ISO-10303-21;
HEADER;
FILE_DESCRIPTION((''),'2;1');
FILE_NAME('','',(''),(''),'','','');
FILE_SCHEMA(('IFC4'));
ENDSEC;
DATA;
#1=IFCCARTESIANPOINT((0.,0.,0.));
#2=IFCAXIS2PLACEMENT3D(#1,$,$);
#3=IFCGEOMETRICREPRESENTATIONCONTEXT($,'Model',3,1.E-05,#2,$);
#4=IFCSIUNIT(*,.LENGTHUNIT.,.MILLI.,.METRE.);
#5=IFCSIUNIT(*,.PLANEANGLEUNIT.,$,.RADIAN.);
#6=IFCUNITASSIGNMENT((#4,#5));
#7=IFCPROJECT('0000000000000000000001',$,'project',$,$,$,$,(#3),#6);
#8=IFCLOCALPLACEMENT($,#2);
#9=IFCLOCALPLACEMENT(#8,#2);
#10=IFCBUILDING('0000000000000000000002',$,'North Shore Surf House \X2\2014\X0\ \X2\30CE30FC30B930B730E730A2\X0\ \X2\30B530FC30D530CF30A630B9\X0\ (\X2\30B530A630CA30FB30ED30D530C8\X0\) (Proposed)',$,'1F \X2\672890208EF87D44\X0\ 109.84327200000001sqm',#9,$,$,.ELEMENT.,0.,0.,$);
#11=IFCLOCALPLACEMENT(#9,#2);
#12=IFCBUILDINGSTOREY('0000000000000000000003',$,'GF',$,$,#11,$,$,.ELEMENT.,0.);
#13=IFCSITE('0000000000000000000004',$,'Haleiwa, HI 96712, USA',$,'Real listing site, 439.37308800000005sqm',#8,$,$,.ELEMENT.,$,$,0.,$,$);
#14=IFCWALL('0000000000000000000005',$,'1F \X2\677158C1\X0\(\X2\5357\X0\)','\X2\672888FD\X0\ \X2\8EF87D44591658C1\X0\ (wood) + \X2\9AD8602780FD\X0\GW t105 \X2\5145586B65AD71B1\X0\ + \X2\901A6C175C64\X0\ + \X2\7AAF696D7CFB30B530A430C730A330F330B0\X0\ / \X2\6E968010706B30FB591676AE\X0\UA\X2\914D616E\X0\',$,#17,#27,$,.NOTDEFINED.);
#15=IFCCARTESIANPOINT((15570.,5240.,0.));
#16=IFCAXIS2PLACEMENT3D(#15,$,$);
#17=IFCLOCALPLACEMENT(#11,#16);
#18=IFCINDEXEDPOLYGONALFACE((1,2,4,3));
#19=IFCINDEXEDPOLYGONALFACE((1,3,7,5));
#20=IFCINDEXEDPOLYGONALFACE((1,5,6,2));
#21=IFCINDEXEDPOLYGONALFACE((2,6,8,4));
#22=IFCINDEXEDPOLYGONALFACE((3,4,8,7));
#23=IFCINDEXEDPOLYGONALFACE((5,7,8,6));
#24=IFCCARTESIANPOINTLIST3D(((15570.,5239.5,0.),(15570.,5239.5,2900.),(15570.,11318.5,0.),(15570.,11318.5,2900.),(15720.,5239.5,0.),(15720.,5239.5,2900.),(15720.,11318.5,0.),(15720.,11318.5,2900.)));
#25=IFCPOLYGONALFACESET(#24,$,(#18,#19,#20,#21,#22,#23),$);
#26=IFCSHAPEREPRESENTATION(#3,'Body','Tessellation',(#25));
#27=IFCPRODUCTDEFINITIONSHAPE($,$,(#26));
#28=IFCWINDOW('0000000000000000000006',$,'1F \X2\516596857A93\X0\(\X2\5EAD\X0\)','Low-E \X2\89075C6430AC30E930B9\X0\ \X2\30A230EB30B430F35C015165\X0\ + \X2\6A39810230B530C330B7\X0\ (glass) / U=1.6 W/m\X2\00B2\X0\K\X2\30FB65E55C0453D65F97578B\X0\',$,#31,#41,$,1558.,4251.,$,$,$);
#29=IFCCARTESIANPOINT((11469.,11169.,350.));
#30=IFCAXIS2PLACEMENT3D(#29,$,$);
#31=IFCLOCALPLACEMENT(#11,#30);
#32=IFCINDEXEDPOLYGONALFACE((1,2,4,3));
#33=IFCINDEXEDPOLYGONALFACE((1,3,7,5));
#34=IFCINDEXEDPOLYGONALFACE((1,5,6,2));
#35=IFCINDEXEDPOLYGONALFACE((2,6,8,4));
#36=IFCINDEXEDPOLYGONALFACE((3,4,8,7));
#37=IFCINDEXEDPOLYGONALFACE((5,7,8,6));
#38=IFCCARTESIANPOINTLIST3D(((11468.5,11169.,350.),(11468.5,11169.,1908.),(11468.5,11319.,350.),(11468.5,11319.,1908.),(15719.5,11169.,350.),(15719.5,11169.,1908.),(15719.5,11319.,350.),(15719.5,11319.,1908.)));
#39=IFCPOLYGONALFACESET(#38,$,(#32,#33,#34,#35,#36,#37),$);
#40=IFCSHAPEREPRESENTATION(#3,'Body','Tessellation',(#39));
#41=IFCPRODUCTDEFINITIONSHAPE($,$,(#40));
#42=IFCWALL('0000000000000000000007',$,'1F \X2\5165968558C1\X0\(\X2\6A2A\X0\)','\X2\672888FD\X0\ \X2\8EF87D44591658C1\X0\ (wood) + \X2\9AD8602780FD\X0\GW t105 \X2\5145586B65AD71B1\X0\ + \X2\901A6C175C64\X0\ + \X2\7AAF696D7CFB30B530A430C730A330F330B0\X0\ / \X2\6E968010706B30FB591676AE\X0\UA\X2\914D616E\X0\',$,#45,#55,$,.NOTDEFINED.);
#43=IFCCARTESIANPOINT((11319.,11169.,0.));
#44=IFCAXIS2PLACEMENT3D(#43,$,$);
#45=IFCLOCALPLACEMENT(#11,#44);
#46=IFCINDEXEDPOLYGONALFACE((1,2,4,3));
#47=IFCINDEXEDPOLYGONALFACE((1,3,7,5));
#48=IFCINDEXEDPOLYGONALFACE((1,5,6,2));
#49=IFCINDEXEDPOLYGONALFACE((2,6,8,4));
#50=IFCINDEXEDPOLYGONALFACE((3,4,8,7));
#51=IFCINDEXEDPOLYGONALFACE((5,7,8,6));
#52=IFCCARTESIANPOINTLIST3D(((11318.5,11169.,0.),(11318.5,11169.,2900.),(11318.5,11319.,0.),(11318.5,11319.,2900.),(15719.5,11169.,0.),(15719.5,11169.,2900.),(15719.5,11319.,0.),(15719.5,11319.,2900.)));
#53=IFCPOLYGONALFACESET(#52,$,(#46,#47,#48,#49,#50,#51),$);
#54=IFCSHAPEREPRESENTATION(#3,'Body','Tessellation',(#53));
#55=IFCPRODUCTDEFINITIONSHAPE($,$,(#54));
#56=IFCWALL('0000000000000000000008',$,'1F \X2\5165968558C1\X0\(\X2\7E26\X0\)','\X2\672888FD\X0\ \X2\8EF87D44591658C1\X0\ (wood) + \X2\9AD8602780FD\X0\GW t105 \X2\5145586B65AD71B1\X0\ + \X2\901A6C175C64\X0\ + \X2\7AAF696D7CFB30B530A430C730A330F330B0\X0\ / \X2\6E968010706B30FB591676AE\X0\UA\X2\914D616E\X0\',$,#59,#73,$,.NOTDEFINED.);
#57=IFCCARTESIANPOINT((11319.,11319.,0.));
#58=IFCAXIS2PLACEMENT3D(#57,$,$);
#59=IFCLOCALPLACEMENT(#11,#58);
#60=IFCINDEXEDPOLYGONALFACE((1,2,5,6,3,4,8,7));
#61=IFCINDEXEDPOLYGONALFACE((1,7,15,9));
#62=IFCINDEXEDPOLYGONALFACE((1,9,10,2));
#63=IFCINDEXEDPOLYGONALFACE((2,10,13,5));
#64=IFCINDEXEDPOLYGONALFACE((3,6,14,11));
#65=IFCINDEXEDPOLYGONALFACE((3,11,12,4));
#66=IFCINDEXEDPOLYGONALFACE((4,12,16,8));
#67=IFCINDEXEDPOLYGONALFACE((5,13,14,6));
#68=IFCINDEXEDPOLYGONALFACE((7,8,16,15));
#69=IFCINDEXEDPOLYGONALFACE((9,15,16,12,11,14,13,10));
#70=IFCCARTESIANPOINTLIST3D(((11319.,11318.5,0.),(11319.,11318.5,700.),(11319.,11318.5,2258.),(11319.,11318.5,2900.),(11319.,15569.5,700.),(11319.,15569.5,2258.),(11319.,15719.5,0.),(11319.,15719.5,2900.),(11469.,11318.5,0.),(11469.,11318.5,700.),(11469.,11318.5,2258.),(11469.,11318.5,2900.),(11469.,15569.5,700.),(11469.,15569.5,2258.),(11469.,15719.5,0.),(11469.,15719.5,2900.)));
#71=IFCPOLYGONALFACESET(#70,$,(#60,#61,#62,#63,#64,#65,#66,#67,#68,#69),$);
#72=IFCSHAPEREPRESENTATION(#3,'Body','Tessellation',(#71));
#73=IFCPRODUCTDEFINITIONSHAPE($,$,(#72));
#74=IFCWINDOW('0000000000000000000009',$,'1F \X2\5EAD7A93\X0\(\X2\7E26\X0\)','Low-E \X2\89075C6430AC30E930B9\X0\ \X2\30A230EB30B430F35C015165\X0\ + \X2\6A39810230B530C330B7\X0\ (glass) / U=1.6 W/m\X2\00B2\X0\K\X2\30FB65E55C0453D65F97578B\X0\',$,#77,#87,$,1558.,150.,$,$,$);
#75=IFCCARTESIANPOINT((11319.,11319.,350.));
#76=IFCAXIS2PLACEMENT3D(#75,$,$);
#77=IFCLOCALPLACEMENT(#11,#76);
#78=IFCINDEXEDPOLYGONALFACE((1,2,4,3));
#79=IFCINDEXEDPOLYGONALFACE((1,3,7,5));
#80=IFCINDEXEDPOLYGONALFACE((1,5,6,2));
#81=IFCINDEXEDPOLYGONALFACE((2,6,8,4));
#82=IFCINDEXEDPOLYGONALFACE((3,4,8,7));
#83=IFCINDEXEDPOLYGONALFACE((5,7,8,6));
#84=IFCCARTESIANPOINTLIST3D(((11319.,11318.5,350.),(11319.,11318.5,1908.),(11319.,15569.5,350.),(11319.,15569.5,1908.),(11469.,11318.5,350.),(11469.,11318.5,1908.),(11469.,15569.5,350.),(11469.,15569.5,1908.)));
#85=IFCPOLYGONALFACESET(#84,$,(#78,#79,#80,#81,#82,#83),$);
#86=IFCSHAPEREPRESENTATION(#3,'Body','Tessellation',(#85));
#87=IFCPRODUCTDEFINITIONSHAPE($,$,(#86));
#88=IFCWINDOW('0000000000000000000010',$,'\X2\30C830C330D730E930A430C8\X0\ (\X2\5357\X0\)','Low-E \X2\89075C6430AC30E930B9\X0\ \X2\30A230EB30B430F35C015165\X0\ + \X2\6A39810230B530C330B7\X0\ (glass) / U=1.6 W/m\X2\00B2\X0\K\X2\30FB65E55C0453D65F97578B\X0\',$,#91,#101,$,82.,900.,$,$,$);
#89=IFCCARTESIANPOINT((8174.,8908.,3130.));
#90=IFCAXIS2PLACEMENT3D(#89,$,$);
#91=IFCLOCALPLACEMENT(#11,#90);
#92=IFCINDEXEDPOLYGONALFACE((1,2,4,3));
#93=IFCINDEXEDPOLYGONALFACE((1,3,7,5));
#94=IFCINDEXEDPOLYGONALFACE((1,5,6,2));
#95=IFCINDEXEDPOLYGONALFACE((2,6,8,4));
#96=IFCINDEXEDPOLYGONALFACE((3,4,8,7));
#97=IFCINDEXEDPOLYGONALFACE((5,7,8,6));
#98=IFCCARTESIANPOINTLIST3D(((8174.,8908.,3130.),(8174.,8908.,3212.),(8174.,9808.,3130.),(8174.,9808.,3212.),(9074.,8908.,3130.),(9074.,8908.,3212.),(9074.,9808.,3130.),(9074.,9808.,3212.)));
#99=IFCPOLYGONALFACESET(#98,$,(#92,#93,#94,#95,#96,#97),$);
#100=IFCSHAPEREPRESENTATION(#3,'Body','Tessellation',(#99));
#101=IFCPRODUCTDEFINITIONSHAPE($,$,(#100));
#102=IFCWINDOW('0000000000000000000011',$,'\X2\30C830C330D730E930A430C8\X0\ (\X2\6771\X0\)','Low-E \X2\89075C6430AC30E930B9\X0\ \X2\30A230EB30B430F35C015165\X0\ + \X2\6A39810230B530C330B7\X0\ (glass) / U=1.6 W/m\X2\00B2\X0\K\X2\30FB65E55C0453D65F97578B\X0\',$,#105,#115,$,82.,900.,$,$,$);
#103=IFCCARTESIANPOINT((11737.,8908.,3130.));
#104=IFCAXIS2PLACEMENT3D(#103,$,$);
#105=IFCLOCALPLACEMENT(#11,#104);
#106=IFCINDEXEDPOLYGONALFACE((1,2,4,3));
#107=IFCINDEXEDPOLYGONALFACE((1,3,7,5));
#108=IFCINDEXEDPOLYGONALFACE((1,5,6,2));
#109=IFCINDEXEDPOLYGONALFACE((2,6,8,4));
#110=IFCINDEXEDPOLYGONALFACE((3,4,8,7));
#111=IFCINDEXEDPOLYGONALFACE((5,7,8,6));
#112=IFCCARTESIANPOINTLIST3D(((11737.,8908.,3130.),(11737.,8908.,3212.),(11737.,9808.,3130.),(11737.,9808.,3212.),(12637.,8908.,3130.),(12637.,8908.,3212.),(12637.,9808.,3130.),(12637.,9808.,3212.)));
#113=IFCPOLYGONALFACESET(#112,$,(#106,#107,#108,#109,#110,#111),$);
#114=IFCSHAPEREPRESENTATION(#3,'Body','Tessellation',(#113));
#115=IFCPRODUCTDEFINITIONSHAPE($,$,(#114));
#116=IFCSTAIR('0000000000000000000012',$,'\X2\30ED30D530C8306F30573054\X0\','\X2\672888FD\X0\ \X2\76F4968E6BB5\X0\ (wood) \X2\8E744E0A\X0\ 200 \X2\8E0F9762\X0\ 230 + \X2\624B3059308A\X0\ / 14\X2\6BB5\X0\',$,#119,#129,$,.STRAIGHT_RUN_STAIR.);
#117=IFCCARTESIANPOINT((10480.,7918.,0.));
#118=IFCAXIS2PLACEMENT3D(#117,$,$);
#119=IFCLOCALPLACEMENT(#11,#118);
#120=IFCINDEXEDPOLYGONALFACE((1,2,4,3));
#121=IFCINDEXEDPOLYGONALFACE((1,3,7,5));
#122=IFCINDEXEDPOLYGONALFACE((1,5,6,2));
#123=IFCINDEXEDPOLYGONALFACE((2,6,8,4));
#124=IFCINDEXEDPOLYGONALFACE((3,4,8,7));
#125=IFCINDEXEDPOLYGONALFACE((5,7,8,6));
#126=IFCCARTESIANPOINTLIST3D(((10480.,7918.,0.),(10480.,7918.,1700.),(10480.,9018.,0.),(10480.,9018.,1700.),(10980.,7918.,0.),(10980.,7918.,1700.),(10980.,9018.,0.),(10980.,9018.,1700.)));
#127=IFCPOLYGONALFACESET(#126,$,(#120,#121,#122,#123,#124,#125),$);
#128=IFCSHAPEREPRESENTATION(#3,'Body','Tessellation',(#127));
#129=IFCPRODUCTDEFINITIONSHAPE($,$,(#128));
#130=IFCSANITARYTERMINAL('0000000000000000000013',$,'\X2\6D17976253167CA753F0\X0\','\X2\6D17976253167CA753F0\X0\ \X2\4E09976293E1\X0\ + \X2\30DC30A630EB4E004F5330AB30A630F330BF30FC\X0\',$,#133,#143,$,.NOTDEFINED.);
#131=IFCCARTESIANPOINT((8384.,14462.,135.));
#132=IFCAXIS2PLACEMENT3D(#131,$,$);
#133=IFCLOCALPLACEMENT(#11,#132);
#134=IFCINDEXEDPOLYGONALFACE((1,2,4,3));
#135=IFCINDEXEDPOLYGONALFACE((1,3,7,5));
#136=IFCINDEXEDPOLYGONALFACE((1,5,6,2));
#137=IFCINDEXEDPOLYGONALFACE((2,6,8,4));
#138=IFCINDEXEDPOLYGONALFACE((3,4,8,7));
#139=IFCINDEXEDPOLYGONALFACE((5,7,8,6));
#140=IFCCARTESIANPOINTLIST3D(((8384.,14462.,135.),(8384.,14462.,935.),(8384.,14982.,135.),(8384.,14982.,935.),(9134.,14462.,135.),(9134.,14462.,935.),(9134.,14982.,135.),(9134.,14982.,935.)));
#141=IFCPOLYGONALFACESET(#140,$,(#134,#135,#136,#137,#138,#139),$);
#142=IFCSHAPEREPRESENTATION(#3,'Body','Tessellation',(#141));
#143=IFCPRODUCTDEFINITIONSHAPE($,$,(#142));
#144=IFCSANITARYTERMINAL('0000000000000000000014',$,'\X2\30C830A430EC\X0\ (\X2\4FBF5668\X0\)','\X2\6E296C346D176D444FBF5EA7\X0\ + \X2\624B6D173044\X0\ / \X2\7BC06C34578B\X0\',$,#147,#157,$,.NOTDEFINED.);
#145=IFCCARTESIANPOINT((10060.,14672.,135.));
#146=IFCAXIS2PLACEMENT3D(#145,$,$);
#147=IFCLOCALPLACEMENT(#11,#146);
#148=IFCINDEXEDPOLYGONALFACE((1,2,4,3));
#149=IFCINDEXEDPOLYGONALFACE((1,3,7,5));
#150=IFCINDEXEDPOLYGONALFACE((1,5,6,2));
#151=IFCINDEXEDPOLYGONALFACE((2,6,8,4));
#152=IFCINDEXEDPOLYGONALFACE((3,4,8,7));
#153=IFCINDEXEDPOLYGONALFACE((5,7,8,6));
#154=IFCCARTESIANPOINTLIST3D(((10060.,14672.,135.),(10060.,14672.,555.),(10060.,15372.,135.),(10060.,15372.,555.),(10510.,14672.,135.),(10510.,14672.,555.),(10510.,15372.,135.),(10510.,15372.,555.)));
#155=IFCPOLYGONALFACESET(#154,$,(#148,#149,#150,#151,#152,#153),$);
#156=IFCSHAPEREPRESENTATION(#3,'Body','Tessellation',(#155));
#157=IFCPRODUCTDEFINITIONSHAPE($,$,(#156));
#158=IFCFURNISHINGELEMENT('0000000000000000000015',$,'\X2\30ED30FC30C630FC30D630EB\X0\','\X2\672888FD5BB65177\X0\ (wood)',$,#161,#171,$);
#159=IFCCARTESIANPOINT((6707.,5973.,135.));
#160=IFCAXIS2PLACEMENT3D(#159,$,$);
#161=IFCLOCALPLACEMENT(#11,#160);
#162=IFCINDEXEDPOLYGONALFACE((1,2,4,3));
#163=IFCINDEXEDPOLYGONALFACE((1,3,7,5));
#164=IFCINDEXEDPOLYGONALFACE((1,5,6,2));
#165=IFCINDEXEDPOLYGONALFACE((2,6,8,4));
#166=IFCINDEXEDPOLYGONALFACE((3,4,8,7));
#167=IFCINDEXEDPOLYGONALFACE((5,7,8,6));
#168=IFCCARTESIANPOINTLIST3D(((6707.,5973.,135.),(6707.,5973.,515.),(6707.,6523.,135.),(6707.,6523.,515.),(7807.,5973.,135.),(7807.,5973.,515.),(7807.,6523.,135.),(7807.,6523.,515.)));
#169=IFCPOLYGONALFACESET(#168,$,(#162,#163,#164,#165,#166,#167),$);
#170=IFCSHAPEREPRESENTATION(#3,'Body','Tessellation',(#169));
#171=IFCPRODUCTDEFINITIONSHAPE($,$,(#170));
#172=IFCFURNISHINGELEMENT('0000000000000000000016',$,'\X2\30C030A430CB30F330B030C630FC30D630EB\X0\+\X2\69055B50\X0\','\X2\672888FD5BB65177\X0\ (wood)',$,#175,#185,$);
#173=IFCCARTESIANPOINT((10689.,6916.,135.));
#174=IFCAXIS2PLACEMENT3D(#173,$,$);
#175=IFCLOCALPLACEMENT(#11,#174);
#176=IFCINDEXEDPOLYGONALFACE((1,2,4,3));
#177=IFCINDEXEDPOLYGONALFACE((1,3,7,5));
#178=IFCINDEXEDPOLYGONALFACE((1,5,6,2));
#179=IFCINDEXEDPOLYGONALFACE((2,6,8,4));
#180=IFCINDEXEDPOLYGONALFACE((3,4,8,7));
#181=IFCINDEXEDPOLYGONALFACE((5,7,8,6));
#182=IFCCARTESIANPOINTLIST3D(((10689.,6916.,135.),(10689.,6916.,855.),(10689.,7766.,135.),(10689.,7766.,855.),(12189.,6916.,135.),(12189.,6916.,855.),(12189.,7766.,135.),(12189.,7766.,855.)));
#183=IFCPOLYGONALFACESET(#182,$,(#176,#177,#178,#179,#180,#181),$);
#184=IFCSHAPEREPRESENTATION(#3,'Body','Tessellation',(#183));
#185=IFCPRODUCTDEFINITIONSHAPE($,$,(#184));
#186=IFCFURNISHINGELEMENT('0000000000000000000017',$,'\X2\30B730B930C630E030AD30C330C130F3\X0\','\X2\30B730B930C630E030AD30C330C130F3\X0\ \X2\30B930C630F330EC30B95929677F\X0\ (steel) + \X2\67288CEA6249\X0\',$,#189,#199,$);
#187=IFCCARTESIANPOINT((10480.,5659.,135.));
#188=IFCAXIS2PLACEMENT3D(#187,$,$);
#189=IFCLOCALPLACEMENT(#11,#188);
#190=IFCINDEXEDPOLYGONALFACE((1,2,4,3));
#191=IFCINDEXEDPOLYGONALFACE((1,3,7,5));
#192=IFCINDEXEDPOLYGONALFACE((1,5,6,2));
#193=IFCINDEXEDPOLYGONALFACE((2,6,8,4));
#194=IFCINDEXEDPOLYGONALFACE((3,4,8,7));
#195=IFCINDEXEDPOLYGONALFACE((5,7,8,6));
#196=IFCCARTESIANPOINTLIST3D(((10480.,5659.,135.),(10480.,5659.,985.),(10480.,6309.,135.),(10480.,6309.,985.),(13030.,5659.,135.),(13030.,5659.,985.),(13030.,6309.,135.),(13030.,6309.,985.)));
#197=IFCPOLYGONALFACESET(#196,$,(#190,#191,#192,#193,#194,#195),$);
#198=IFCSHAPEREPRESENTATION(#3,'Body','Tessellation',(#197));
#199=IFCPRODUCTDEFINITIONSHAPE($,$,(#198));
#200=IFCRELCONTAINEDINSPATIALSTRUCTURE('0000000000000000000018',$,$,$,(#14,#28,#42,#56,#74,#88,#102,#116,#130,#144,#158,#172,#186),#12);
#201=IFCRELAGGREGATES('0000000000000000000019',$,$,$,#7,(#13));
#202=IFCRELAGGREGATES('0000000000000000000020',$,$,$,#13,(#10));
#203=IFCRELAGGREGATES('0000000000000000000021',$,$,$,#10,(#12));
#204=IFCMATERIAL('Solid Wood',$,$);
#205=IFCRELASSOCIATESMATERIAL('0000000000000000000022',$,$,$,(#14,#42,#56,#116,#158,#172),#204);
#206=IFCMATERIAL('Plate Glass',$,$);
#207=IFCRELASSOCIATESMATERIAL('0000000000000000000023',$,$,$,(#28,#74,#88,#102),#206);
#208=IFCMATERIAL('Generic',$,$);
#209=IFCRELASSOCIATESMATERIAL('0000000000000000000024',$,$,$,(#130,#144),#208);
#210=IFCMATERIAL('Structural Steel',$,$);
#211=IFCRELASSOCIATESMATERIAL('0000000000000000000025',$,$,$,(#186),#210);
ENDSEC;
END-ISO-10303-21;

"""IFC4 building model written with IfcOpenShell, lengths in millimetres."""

from ifc_helpers import new_model, si_unit, frame, frame_2d, origin, place, context, project, spatial, rectangle, extrude, material, element, fill, save


model = new_model("IFC4")

# Units and contexts
model_context = context("Model", 3, precision=1e-05, world=origin())
ifc_project = project(units=[si_unit("LENGTHUNIT", "METRE", prefix="MILLI"), si_unit("PLANEANGLEUNIT", "RADIAN")], contexts=[model_context])

# Site, building, storey
site_placement = place(None, origin())
site = spatial("IfcSite", under=ifc_project, at=site_placement, Name="Haleiwa, HI 96712, USA", ObjectType="Real listing site, 439.37308800000005sqm", CompositionType="ELEMENT", RefElevation=0.0)
building_placement = place(site_placement, origin())
building = spatial("IfcBuilding", under=site, at=building_placement, Name="North Shore Surf House — ノースショア サーフハウス (サウナ・ロフト) (Proposed)", ObjectType="1F 木造軸組 109.84327200000001sqm", CompositionType="ELEMENT", ElevationOfRefHeight=0.0, ElevationOfTerrain=0.0)
storey_placement = place(building_placement, origin())
storey = spatial("IfcBuildingStorey", under=building, at=storey_placement, Name="GF", CompositionType="ELEMENT", Elevation=0.0)

# Shared definitions
ifc_material_1 = material(Name="Solid Wood")

# Wall, opening, window
wall_1_placement = place(storey_placement, frame((15570.0, 5240.0, 0.0)))
wall_1 = element("IfcWall", 1, at=wall_1_placement, inside=storey, material=ifc_material_1, Name="1F 東壁(南)", Description="木製 軸組外壁 (wood) + 高性能GW t105 充填断熱 + 通気層 + 窯業系サイディング / 準耐火・外皮UA配慮", PredefinedType="NOTDEFINED", context=model_context, shape_type="SweptSolid", body=[
    extrude(rectangle(XDim=150.0, YDim=6079.0, at=frame_2d((75.0, 3039.0))), frame((15570.0, 5240.0, 0.0)), (0.0, 0.0, 1.0), 2900.0),
])
opening_1_placement = place(storey_placement, frame((11469.0, 11169.0, 350.0)))
opening_1 = element("IfcOpeningElement", 2, at=opening_1_placement, cuts=wall_1, PredefinedType="NOTDEFINED", context=model_context, shape_type="SweptSolid", body=[
    extrude(rectangle(XDim=4251.0, YDim=150.0, at=frame_2d((2125.0, 75.0))), frame((11469.0, 11169.0, 350.0)), (0.0, 0.0, 1.0), 1558.0),
])
ifc_material_2 = material(Name="Plate Glass")
window_1_placement = place(storey_placement, frame((11469.0, 11169.0, 350.0)))
window_1 = element("IfcWindow", 3, at=window_1_placement, inside=storey, material=ifc_material_2, Name="1F 入隅窓(庭)", Description="Low-E 複層ガラス アルゴン封入 + 樹脂サッシ (glass) / U=1.6 W/m²K・日射取得型", OverallHeight=1558.0, OverallWidth=4251.0, context=model_context, shape_type="SweptSolid", body=[
    extrude(rectangle(XDim=4251.0, YDim=150.0, at=frame_2d((2125.0, 75.0))), frame((11469.0, 11169.0, 350.0)), (0.0, 0.0, 1.0), 1558.0),
])
fill(opening_1, window_1)

# Wall
wall_2_placement = place(storey_placement, frame((11319.0, 11169.0, 0.0)))
element("IfcWall", 4, at=wall_2_placement, inside=storey, material=ifc_material_1, Name="1F 入隅壁(横)", Description="木製 軸組外壁 (wood) + 高性能GW t105 充填断熱 + 通気層 + 窯業系サイディング / 準耐火・外皮UA配慮", PredefinedType="NOTDEFINED", context=model_context, shape_type="SweptSolid", body=[
    extrude(rectangle(XDim=4401.0, YDim=150.0, at=frame_2d((2200.0, 75.0))), frame((11319.0, 11169.0, 0.0)), (0.0, 0.0, 1.0), 2900.0),
])

# Wall, opening, window
wall_3_placement = place(storey_placement, frame((11319.0, 11319.0, 0.0)))
wall_3 = element("IfcWall", 5, at=wall_3_placement, inside=storey, material=ifc_material_1, Name="1F 入隅壁(縦)", Description="木製 軸組外壁 (wood) + 高性能GW t105 充填断熱 + 通気層 + 窯業系サイディング / 準耐火・外皮UA配慮", PredefinedType="NOTDEFINED", context=model_context, shape_type="SweptSolid", body=[
    extrude(rectangle(XDim=150.0, YDim=4401.0, at=frame_2d((75.0, 2200.0))), frame((11319.0, 11319.0, 0.0)), (0.0, 0.0, 1.0), 2900.0),
])
opening_2_placement = place(storey_placement, frame((11319.0, 11319.0, 350.0)))
opening_2 = element("IfcOpeningElement", 6, at=opening_2_placement, cuts=wall_3, PredefinedType="NOTDEFINED", context=model_context, shape_type="SweptSolid", body=[
    extrude(rectangle(XDim=150.0, YDim=4251.0, at=frame_2d((75.0, 2125.0))), frame((11319.0, 11319.0, 350.0)), (0.0, 0.0, 1.0), 1558.0),
])
window_2_placement = place(storey_placement, frame((11319.0, 11319.0, 350.0)))
window_2 = element("IfcWindow", 7, at=window_2_placement, inside=storey, material=ifc_material_2, Name="1F 庭窓(縦)", Description="Low-E 複層ガラス アルゴン封入 + 樹脂サッシ (glass) / U=1.6 W/m²K・日射取得型", OverallHeight=1558.0, OverallWidth=150.0, context=model_context, shape_type="SweptSolid", body=[
    extrude(rectangle(XDim=150.0, YDim=4251.0, at=frame_2d((75.0, 2125.0))), frame((11319.0, 11319.0, 350.0)), (0.0, 0.0, 1.0), 1558.0),
])
fill(opening_2, window_2)

# Windows
window_3_placement = place(storey_placement, frame((8174.0, 8908.0, 3130.0)))
element("IfcWindow", 8, at=window_3_placement, inside=storey, material=ifc_material_2, Name="トップライト (南)", Description="Low-E 複層ガラス アルゴン封入 + 樹脂サッシ (glass) / U=1.6 W/m²K・日射取得型", OverallHeight=82.0, OverallWidth=900.0, context=model_context, shape_type="SweptSolid", body=[
    extrude(rectangle(XDim=900.0, YDim=900.0, at=frame_2d((450.0, 450.0))), frame((8174.0, 8908.0, 3130.0)), (0.0, 0.0, 1.0), 82.0),
])
window_4_placement = place(storey_placement, frame((11737.0, 8908.0, 3130.0)))
element("IfcWindow", 9, at=window_4_placement, inside=storey, material=ifc_material_2, Name="トップライト (東)", Description="Low-E 複層ガラス アルゴン封入 + 樹脂サッシ (glass) / U=1.6 W/m²K・日射取得型", OverallHeight=82.0, OverallWidth=900.0, context=model_context, shape_type="SweptSolid", body=[
    extrude(rectangle(XDim=900.0, YDim=900.0, at=frame_2d((450.0, 450.0))), frame((11737.0, 8908.0, 3130.0)), (0.0, 0.0, 1.0), 82.0),
])

# Stair
stair_placement = place(storey_placement, frame((10480.0, 7918.0, 0.0)))
element("IfcStair", 10, at=stair_placement, inside=storey, material=ifc_material_1, Name="ロフトはしご", Description="木製 直階段 (wood) 蹴上 200 踏面 230 + 手すり / 14段", PredefinedType="STRAIGHT_RUN_STAIR", context=model_context, shape_type="SweptSolid", body=[
    extrude(rectangle(XDim=500.0, YDim=1100.0, at=frame_2d((250.0, 550.0))), frame((10480.0, 7918.0, 0.0)), (0.0, 0.0, 1.0), 1700.0),
])

# Sanitary terminals
ifc_material_3 = material(Name="Generic")
sanitary_terminal_1_placement = place(storey_placement, frame((8384.0, 14462.0, 135.0)))
element("IfcSanitaryTerminal", 11, at=sanitary_terminal_1_placement, inside=storey, material=ifc_material_3, Name="洗面化粧台", Description="洗面化粧台 三面鏡 + ボウル一体カウンター", PredefinedType="NOTDEFINED", context=model_context, shape_type="SweptSolid", body=[
    extrude(rectangle(XDim=750.0, YDim=520.0, at=frame_2d((375.0, 260.0))), frame((8384.0, 14462.0, 135.0)), (0.0, 0.0, 1.0), 800.0),
])
sanitary_terminal_2_placement = place(storey_placement, frame((10060.0, 14672.0, 135.0)))
element("IfcSanitaryTerminal", 12, at=sanitary_terminal_2_placement, inside=storey, material=ifc_material_3, Name="トイレ (便器)", Description="温水洗浄便座 + 手洗い / 節水型", PredefinedType="NOTDEFINED", context=model_context, shape_type="SweptSolid", body=[
    extrude(rectangle(XDim=450.0, YDim=700.0, at=frame_2d((225.0, 350.0))), frame((10060.0, 14672.0, 135.0)), (0.0, 0.0, 1.0), 420.0),
])

# Furnishing elements
furnishing_1_placement = place(storey_placement, frame((6707.0, 5973.0, 135.0)))
element("IfcFurnishingElement", 13, at=furnishing_1_placement, inside=storey, material=ifc_material_1, Name="ローテーブル", Description="木製家具 (wood)", context=model_context, shape_type="SweptSolid", body=[
    extrude(rectangle(XDim=1100.0, YDim=550.0, at=frame_2d((550.0, 275.0))), frame((6707.0, 5973.0, 135.0)), (0.0, 0.0, 1.0), 380.0),
])
furnishing_2_placement = place(storey_placement, frame((10689.0, 6916.0, 135.0)))
element("IfcFurnishingElement", 14, at=furnishing_2_placement, inside=storey, material=ifc_material_1, Name="ダイニングテーブル+椅子", Description="木製家具 (wood)", context=model_context, shape_type="SweptSolid", body=[
    extrude(rectangle(XDim=1500.0, YDim=850.0, at=frame_2d((750.0, 425.0))), frame((10689.0, 6916.0, 135.0)), (0.0, 0.0, 1.0), 720.0),
])
ifc_material_4 = material(Name="Structural Steel")
furnishing_3_placement = place(storey_placement, frame((10480.0, 5659.0, 135.0)))
element("IfcFurnishingElement", 15, at=furnishing_3_placement, inside=storey, material=ifc_material_4, Name="システムキッチン", Description="システムキッチン ステンレス天板 (steel) + 木質扉", context=model_context, shape_type="SweptSolid", body=[
    extrude(rectangle(XDim=2550.0, YDim=650.0, at=frame_2d((1275.0, 325.0))), frame((10480.0, 5659.0, 135.0)), (0.0, 0.0, 1.0), 850.0),
])

save(model, "model.ifc")
